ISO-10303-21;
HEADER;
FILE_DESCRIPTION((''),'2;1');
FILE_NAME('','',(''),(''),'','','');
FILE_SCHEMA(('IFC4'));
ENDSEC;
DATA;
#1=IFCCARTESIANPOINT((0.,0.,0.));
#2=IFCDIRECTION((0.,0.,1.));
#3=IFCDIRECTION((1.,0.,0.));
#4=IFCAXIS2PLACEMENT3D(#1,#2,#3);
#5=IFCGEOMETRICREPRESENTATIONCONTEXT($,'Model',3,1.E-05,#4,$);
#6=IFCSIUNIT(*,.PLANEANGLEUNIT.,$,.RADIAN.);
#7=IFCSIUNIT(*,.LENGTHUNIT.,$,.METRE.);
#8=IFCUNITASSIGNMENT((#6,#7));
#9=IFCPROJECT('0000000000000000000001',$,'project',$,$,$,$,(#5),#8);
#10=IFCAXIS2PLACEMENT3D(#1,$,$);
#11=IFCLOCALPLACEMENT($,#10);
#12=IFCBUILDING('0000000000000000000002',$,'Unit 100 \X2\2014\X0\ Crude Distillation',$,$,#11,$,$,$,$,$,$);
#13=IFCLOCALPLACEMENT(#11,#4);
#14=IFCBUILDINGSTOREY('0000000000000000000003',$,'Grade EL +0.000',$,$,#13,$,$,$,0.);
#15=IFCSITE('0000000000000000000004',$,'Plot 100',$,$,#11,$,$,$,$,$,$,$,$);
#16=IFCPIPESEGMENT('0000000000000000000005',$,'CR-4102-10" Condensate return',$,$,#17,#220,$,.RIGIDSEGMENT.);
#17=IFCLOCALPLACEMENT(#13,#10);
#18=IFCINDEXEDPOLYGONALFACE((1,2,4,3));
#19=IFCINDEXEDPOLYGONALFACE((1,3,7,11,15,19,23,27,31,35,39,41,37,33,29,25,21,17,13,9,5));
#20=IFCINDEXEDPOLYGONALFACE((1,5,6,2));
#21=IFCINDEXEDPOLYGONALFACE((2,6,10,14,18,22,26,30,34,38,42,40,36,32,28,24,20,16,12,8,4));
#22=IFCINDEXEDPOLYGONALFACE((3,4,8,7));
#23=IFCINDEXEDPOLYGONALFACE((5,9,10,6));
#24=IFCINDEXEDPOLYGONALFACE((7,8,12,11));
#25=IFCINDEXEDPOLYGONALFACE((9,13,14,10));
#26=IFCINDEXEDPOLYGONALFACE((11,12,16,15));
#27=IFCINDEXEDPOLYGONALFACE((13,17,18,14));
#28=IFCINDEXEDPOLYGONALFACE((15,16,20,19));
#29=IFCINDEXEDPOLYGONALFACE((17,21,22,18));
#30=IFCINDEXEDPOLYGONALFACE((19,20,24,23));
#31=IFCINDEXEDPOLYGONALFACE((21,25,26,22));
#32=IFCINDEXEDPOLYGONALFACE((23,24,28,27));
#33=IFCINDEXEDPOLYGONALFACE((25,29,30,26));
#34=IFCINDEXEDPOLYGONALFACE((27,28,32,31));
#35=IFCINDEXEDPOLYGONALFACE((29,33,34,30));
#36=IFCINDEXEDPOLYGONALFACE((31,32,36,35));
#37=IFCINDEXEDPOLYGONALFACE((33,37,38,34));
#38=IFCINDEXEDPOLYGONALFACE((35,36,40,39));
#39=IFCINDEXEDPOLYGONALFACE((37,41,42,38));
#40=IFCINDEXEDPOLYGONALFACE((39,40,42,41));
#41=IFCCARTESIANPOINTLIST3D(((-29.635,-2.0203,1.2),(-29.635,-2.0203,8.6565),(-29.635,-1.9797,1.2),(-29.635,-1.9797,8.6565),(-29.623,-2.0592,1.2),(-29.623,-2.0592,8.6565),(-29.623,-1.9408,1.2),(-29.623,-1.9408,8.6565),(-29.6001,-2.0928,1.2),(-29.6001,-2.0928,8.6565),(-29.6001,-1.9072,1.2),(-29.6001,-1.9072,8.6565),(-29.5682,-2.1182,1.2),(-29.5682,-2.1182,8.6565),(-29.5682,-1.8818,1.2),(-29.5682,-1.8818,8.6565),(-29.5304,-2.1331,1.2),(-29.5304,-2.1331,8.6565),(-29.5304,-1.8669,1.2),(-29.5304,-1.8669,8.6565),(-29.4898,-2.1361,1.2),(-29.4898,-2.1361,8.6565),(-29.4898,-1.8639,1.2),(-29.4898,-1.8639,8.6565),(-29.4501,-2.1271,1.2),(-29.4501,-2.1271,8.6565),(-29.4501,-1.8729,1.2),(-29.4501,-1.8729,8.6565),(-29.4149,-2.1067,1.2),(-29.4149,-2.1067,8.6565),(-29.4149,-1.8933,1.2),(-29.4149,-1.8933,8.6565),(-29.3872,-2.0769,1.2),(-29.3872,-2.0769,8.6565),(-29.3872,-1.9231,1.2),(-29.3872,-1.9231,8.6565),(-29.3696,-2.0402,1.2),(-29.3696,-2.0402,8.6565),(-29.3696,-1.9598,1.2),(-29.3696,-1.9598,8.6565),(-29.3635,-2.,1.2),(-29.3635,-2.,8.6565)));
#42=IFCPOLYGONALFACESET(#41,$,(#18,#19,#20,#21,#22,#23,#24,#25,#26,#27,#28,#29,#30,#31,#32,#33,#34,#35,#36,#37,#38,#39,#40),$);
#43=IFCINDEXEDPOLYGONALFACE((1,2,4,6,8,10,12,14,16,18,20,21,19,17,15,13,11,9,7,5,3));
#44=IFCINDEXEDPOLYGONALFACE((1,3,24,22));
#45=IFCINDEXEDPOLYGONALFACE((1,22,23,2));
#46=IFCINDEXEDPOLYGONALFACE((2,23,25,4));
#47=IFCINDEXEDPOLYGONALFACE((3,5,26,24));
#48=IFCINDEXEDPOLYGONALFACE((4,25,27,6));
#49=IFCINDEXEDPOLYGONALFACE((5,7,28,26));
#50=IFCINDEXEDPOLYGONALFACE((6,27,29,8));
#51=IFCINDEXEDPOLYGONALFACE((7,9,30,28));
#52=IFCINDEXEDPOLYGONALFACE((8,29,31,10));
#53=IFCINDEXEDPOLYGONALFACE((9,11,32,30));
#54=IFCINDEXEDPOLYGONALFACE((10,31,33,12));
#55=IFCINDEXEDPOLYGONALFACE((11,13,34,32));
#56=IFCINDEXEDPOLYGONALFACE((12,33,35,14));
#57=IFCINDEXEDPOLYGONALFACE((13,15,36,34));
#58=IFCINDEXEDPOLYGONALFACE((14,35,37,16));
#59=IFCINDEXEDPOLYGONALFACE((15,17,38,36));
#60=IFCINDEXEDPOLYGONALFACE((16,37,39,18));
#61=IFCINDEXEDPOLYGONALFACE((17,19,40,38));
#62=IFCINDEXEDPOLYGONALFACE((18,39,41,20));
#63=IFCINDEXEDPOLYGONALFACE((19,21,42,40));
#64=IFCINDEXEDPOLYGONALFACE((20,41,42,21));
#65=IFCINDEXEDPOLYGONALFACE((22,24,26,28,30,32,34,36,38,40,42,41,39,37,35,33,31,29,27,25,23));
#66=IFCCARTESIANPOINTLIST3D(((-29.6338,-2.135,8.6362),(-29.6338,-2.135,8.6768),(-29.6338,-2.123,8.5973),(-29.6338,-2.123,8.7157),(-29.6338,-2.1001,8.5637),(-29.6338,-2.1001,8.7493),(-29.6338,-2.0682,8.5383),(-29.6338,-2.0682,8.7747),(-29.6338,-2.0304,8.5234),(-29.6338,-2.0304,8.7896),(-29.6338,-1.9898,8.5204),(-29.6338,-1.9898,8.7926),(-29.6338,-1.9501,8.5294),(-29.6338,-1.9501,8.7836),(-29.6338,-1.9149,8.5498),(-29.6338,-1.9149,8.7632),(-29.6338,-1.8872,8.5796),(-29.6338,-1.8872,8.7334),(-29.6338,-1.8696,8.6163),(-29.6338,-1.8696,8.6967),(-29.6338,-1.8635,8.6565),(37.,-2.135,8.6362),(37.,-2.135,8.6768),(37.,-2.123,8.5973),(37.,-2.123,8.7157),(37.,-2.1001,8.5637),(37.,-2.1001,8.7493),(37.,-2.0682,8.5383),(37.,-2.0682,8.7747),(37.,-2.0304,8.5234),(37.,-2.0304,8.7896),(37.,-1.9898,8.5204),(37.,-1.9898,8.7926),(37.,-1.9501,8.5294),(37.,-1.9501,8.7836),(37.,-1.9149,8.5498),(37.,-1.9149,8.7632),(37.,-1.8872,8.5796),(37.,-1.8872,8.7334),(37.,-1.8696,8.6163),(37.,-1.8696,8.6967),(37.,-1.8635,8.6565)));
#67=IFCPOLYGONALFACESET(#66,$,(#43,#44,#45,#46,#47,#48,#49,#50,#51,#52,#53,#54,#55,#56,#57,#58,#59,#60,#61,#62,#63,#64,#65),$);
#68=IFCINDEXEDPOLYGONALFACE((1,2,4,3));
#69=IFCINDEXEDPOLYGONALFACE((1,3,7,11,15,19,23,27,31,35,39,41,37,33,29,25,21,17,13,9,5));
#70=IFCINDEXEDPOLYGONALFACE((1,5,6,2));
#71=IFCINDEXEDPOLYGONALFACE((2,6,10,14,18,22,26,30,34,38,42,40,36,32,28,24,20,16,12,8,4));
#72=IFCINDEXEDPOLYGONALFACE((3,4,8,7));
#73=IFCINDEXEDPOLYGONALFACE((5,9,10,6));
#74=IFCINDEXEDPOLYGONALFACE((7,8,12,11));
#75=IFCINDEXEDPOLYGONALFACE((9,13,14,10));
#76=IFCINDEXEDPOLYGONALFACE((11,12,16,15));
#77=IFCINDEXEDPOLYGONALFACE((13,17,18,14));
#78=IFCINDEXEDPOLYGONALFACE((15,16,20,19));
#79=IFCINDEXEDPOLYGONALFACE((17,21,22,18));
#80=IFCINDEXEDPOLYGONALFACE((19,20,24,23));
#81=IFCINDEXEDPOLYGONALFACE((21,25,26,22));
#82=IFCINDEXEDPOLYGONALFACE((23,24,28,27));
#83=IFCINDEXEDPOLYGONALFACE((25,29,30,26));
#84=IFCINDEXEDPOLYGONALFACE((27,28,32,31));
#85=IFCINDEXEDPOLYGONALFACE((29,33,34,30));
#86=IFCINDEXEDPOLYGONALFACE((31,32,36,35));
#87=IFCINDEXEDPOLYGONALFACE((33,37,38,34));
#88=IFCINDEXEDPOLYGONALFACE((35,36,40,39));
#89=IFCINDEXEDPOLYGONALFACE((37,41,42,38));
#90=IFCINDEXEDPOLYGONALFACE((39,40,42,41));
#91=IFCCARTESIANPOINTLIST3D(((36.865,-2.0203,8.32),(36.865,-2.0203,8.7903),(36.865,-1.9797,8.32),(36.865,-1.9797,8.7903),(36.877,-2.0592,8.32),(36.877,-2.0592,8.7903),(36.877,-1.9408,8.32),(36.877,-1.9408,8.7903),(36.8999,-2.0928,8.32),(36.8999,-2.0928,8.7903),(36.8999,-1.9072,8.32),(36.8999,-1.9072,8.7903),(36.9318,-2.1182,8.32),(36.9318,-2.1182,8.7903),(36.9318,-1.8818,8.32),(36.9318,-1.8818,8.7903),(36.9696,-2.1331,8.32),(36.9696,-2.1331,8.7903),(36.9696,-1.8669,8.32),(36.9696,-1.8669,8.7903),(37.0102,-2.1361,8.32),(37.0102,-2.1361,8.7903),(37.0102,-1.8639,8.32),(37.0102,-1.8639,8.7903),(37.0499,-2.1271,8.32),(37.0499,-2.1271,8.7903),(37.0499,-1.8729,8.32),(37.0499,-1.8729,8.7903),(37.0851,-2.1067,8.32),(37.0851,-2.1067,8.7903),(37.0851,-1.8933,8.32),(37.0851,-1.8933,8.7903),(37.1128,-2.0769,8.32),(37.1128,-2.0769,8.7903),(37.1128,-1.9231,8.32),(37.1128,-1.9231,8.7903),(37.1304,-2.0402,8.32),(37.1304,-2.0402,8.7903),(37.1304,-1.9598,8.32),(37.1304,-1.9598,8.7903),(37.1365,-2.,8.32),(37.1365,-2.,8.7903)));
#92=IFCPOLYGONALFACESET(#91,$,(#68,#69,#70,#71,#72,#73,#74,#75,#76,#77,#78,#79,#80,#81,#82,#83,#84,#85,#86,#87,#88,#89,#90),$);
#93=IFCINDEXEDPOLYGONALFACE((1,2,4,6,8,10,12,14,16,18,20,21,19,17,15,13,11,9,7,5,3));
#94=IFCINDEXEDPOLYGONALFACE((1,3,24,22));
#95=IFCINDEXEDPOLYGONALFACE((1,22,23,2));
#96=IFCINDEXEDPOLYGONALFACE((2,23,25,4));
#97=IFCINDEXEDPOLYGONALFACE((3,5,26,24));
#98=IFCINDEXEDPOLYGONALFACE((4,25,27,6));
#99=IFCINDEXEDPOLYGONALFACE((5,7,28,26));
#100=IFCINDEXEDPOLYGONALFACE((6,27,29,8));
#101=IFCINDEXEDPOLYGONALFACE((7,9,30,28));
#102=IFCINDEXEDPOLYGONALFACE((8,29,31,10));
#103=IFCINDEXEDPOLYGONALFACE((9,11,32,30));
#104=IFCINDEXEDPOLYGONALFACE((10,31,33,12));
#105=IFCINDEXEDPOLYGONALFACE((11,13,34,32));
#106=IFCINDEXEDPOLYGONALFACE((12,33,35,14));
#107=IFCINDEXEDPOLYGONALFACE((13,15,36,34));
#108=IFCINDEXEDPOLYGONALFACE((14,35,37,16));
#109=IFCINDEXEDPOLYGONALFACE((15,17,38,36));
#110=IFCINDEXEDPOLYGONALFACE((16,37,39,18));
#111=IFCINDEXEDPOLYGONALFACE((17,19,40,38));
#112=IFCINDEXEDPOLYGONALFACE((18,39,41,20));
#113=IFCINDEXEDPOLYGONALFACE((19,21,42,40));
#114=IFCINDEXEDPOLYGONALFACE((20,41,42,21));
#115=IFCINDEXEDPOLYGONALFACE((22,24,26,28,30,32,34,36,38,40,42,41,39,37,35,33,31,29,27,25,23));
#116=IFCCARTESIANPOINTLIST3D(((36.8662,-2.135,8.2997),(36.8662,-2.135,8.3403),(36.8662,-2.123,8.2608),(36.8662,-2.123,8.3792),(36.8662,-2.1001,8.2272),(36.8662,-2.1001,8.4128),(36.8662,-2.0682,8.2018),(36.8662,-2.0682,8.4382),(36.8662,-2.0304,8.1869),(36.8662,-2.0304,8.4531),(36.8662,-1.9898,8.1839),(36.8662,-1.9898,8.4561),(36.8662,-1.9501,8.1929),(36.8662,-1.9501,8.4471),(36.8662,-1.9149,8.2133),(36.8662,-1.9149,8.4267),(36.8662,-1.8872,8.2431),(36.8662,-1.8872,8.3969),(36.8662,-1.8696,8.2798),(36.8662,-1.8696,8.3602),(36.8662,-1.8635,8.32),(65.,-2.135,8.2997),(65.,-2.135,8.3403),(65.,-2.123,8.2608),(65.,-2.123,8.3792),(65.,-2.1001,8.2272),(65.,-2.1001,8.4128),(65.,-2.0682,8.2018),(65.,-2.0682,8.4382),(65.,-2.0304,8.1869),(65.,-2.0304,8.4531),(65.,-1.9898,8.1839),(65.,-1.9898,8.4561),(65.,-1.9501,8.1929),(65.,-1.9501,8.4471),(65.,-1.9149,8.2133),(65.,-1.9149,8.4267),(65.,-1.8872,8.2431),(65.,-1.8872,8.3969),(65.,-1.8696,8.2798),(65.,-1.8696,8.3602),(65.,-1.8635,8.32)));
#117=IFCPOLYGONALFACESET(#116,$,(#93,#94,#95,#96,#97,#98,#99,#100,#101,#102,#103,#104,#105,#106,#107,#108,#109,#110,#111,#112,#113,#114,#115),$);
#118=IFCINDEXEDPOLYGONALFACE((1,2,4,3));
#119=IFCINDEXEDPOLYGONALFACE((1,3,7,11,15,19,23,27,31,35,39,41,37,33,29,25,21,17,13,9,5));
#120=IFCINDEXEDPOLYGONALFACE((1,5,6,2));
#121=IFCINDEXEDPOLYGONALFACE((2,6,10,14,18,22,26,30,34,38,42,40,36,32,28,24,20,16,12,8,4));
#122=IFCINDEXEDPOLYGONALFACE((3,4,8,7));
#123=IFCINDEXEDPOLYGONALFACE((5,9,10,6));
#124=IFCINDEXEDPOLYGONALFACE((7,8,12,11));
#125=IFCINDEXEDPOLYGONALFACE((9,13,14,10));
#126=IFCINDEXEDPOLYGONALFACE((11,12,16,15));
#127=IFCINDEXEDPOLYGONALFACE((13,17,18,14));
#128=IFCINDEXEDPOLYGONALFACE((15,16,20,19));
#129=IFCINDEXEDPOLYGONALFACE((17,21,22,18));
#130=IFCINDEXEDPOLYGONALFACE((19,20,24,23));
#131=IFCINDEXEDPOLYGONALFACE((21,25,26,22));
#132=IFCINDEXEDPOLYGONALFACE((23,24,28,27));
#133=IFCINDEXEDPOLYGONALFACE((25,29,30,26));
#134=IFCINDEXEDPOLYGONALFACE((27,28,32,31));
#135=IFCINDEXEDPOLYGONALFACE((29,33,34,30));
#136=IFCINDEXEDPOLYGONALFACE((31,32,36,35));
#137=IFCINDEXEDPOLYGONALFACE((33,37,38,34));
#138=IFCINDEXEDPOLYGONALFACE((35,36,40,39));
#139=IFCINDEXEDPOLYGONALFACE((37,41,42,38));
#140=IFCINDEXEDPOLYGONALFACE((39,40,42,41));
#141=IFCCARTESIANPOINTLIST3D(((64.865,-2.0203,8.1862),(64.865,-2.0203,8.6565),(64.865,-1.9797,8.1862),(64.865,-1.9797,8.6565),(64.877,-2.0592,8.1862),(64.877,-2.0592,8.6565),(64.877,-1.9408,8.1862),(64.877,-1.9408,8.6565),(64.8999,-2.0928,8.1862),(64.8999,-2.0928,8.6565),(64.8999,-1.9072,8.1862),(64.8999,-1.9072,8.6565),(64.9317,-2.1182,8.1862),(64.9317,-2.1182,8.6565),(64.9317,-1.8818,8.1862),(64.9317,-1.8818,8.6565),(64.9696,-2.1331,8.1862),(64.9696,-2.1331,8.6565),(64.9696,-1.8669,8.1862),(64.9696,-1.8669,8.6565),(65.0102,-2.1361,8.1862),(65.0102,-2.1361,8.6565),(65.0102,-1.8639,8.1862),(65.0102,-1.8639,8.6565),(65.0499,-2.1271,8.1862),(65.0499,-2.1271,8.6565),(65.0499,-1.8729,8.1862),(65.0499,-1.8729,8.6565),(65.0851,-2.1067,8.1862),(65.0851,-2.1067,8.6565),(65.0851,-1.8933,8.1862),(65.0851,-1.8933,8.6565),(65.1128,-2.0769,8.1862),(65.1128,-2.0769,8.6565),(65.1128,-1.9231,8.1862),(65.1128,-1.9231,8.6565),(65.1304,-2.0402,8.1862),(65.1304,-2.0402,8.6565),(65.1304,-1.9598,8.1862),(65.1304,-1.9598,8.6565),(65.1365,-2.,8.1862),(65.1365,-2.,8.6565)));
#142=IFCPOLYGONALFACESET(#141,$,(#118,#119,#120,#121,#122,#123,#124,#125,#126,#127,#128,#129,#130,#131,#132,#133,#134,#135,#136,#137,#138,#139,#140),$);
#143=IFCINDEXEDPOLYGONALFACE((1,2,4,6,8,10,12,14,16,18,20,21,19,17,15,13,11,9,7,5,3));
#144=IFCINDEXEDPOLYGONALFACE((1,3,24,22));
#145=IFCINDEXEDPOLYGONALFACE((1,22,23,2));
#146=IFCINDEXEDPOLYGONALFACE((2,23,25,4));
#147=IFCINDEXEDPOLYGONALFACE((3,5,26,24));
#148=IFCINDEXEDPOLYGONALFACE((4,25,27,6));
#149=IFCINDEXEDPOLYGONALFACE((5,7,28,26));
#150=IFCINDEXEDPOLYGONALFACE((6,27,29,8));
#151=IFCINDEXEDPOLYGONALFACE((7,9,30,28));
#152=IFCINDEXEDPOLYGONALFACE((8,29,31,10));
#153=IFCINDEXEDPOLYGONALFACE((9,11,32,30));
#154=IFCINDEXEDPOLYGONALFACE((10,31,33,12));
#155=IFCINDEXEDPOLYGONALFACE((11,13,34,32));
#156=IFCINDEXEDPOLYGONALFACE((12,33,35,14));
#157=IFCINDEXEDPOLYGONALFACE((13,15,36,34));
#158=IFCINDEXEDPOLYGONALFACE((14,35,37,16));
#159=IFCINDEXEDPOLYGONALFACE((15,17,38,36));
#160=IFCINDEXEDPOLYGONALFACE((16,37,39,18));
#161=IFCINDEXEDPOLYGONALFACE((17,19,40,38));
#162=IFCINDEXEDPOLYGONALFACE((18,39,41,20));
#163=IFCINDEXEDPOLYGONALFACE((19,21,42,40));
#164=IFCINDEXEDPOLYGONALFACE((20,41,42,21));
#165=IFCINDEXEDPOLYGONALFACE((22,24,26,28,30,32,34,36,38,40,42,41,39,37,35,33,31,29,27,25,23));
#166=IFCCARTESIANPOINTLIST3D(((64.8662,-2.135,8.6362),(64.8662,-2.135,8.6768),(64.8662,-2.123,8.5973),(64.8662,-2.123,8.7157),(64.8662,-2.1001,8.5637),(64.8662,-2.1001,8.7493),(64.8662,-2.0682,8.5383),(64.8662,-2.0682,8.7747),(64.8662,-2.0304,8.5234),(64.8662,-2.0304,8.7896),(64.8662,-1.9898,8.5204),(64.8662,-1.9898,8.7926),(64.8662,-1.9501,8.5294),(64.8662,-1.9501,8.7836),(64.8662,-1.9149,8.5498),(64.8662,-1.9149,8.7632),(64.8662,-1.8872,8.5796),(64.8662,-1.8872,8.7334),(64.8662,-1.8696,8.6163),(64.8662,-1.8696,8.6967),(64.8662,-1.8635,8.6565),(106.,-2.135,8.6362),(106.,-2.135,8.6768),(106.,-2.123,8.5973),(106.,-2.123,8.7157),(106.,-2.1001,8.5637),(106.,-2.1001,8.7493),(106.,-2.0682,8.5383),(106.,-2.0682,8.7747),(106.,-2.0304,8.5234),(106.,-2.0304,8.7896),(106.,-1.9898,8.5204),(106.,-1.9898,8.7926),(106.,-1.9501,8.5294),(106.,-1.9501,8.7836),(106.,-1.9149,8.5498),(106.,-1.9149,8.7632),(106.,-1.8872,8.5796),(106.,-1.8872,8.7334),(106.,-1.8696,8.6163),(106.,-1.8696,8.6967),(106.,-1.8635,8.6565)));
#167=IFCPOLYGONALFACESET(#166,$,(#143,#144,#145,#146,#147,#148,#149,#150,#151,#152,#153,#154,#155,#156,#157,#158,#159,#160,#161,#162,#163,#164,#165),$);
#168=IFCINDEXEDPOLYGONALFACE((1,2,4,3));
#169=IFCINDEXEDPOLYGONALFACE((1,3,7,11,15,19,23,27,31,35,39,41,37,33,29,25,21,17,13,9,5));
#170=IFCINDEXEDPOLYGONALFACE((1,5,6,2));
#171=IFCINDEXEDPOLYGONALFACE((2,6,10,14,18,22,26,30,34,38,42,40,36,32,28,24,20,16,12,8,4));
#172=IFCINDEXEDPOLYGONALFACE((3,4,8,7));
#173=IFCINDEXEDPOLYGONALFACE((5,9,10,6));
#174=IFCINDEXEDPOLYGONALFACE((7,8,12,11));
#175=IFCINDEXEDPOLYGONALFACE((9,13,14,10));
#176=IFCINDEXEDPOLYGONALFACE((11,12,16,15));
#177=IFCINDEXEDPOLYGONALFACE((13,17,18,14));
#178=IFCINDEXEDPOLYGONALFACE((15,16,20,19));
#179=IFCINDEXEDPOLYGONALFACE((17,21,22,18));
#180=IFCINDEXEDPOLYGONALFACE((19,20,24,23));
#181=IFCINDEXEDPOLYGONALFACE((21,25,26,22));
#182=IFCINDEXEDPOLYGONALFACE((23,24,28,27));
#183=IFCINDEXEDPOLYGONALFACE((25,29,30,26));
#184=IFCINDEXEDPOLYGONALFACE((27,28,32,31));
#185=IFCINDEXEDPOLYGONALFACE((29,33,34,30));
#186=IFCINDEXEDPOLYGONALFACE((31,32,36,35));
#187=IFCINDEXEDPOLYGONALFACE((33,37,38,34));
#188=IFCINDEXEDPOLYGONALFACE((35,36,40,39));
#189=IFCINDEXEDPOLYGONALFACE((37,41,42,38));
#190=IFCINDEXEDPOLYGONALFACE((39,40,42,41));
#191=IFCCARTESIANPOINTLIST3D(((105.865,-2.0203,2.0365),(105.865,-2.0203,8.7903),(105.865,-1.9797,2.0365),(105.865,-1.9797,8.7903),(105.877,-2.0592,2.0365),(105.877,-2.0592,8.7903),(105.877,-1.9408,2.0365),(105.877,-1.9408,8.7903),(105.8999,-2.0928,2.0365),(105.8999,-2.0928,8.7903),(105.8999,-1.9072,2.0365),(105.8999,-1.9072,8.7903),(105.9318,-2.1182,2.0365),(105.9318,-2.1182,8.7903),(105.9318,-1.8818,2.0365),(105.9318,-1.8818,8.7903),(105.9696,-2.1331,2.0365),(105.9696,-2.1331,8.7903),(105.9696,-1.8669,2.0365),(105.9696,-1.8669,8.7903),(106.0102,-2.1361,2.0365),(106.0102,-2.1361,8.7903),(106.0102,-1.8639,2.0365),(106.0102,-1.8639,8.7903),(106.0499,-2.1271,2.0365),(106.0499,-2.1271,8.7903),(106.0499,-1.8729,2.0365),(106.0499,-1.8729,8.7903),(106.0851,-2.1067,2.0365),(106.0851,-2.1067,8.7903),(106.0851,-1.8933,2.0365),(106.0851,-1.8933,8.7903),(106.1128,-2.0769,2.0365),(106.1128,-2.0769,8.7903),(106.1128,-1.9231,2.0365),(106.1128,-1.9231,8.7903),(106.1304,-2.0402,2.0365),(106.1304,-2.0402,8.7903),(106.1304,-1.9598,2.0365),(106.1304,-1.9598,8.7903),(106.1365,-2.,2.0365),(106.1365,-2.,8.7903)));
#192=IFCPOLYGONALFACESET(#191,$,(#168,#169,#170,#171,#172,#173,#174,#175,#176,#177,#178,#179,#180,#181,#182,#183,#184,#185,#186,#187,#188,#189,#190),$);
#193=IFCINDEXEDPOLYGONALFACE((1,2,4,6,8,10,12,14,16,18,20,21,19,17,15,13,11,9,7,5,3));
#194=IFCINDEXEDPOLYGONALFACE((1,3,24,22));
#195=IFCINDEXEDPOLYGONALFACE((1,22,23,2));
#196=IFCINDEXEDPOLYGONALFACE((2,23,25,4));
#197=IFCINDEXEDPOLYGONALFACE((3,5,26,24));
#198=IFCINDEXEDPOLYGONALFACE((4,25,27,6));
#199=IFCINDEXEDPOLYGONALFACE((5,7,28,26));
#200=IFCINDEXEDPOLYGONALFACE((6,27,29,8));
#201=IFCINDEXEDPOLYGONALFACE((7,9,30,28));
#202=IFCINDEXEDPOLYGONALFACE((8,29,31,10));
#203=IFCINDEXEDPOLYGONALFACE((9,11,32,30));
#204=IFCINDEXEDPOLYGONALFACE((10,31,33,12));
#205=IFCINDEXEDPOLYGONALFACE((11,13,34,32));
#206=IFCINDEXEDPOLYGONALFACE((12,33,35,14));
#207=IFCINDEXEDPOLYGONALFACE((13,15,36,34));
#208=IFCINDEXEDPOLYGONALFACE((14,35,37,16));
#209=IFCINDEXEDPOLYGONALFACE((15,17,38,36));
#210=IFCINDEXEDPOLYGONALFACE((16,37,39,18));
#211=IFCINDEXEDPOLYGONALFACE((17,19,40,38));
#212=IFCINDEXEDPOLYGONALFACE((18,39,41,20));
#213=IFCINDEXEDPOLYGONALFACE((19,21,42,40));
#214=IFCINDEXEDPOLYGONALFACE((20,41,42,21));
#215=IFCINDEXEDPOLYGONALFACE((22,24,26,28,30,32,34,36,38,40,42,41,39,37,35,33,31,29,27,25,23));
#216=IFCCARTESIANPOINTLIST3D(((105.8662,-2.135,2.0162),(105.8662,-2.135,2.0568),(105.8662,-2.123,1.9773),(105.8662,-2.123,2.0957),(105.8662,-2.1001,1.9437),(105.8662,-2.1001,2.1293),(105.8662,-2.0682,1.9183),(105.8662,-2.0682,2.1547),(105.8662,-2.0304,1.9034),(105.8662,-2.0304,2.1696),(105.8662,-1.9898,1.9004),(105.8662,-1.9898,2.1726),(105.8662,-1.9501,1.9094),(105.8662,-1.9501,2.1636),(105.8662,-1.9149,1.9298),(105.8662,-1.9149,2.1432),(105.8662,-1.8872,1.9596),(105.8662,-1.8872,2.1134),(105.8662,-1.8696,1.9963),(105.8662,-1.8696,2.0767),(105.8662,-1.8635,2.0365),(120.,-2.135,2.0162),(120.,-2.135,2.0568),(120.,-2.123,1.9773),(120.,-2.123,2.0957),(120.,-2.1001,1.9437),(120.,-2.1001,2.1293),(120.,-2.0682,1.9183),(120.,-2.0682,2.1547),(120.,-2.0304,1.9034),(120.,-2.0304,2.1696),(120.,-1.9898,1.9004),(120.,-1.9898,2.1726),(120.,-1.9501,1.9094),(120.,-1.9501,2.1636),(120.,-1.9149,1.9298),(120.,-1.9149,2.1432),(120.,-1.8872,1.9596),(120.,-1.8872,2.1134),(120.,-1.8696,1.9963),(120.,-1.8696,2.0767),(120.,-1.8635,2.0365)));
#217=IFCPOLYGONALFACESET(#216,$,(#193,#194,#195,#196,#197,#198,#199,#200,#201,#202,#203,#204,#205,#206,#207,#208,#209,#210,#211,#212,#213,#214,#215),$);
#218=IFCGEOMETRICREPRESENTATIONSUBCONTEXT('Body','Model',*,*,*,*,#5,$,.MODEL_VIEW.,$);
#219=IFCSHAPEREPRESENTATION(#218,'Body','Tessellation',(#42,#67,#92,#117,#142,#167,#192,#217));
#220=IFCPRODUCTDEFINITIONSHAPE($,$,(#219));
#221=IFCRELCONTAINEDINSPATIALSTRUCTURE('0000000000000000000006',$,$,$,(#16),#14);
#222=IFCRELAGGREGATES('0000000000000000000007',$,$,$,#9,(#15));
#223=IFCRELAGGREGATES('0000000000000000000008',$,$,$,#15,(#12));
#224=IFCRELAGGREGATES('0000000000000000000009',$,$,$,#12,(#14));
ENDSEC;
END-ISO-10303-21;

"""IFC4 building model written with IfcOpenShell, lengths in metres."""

from ifc_helpers import new_model, si_unit, frame, origin, origin_with_axes, origin_2d, place, context, subcontext, project, spatial, circle, extrude, element, save


model = new_model("IFC4")

# Units and contexts
model_context = context("Model", 3, precision=1e-05, world=origin_with_axes())
body_context = subcontext(model_context, "Body", "Model", "MODEL_VIEW")
ifc_project = project(units=[si_unit("PLANEANGLEUNIT", "RADIAN"), si_unit("LENGTHUNIT", "METRE")], contexts=[model_context])

# Site, building, storey
placement = place(None, origin())
site = spatial("IfcSite", under=ifc_project, at=placement, Name="Plot 100")
building = spatial("IfcBuilding", under=site, at=placement, Name="Unit 100 — Crude Distillation")
storey_placement = place(placement, origin_with_axes())
storey = spatial("IfcBuildingStorey", under=building, at=storey_placement, Name="Grade EL +0.000", Elevation=0.0)

# Pipe segment
pipe_segment_1_placement = place(storey_placement, origin_with_axes())
element("IfcPipeSegment", 1, at=pipe_segment_1_placement, inside=storey, Name="CR-4102-10\" Condensate return", PredefinedType="RIGIDSEGMENT", context=body_context, shape_type="SweptSolid", body=[
    extrude(circle(Radius=0.1365, at=origin_2d()), frame((-29.5, -2.0, 1.2), z_axis=(0.0, 0.0, 1.0), x_axis=(1.0, 0.0, 0.0)), (0.0, 0.0, 1.0), 7.4565),
    extrude(circle(Radius=0.1365, at=origin_2d()), frame((-29.6338, -2.0, 8.6565), z_axis=(1.0, 0.0, 0.0), x_axis=(0.0, 1.0, 0.0)), (0.0, 0.0, 1.0), 66.6338),
    extrude(circle(Radius=0.1365, at=origin_2d()), frame((37.0, -2.0, 8.7903), z_axis=(0.0, 0.0, -1.0), x_axis=(1.0, 0.0, 0.0)), (0.0, 0.0, 1.0), 0.4703),
    extrude(circle(Radius=0.1365, at=origin_2d()), frame((36.8662, -2.0, 8.32), z_axis=(1.0, 0.0, 0.0), x_axis=(0.0, 1.0, 0.0)), (0.0, 0.0, 1.0), 28.1338),
    extrude(circle(Radius=0.1365, at=origin_2d()), frame((65.0, -2.0, 8.1862), z_axis=(0.0, 0.0, 1.0), x_axis=(1.0, 0.0, 0.0)), (0.0, 0.0, 1.0), 0.4703),
    extrude(circle(Radius=0.1365, at=origin_2d()), frame((64.8662, -2.0, 8.6565), z_axis=(1.0, 0.0, 0.0), x_axis=(0.0, 1.0, 0.0)), (0.0, 0.0, 1.0), 41.1338),
    extrude(circle(Radius=0.1365, at=origin_2d()), frame((106.0, -2.0, 8.7903), z_axis=(0.0, 0.0, -1.0), x_axis=(1.0, 0.0, 0.0)), (0.0, 0.0, 1.0), 6.7538),
    extrude(circle(Radius=0.1365, at=origin_2d()), frame((105.8662, -2.0, 2.0365), z_axis=(1.0, 0.0, 0.0), x_axis=(0.0, 1.0, 0.0)), (0.0, 0.0, 1.0), 14.1338),
])

save(model, "model.ifc")
